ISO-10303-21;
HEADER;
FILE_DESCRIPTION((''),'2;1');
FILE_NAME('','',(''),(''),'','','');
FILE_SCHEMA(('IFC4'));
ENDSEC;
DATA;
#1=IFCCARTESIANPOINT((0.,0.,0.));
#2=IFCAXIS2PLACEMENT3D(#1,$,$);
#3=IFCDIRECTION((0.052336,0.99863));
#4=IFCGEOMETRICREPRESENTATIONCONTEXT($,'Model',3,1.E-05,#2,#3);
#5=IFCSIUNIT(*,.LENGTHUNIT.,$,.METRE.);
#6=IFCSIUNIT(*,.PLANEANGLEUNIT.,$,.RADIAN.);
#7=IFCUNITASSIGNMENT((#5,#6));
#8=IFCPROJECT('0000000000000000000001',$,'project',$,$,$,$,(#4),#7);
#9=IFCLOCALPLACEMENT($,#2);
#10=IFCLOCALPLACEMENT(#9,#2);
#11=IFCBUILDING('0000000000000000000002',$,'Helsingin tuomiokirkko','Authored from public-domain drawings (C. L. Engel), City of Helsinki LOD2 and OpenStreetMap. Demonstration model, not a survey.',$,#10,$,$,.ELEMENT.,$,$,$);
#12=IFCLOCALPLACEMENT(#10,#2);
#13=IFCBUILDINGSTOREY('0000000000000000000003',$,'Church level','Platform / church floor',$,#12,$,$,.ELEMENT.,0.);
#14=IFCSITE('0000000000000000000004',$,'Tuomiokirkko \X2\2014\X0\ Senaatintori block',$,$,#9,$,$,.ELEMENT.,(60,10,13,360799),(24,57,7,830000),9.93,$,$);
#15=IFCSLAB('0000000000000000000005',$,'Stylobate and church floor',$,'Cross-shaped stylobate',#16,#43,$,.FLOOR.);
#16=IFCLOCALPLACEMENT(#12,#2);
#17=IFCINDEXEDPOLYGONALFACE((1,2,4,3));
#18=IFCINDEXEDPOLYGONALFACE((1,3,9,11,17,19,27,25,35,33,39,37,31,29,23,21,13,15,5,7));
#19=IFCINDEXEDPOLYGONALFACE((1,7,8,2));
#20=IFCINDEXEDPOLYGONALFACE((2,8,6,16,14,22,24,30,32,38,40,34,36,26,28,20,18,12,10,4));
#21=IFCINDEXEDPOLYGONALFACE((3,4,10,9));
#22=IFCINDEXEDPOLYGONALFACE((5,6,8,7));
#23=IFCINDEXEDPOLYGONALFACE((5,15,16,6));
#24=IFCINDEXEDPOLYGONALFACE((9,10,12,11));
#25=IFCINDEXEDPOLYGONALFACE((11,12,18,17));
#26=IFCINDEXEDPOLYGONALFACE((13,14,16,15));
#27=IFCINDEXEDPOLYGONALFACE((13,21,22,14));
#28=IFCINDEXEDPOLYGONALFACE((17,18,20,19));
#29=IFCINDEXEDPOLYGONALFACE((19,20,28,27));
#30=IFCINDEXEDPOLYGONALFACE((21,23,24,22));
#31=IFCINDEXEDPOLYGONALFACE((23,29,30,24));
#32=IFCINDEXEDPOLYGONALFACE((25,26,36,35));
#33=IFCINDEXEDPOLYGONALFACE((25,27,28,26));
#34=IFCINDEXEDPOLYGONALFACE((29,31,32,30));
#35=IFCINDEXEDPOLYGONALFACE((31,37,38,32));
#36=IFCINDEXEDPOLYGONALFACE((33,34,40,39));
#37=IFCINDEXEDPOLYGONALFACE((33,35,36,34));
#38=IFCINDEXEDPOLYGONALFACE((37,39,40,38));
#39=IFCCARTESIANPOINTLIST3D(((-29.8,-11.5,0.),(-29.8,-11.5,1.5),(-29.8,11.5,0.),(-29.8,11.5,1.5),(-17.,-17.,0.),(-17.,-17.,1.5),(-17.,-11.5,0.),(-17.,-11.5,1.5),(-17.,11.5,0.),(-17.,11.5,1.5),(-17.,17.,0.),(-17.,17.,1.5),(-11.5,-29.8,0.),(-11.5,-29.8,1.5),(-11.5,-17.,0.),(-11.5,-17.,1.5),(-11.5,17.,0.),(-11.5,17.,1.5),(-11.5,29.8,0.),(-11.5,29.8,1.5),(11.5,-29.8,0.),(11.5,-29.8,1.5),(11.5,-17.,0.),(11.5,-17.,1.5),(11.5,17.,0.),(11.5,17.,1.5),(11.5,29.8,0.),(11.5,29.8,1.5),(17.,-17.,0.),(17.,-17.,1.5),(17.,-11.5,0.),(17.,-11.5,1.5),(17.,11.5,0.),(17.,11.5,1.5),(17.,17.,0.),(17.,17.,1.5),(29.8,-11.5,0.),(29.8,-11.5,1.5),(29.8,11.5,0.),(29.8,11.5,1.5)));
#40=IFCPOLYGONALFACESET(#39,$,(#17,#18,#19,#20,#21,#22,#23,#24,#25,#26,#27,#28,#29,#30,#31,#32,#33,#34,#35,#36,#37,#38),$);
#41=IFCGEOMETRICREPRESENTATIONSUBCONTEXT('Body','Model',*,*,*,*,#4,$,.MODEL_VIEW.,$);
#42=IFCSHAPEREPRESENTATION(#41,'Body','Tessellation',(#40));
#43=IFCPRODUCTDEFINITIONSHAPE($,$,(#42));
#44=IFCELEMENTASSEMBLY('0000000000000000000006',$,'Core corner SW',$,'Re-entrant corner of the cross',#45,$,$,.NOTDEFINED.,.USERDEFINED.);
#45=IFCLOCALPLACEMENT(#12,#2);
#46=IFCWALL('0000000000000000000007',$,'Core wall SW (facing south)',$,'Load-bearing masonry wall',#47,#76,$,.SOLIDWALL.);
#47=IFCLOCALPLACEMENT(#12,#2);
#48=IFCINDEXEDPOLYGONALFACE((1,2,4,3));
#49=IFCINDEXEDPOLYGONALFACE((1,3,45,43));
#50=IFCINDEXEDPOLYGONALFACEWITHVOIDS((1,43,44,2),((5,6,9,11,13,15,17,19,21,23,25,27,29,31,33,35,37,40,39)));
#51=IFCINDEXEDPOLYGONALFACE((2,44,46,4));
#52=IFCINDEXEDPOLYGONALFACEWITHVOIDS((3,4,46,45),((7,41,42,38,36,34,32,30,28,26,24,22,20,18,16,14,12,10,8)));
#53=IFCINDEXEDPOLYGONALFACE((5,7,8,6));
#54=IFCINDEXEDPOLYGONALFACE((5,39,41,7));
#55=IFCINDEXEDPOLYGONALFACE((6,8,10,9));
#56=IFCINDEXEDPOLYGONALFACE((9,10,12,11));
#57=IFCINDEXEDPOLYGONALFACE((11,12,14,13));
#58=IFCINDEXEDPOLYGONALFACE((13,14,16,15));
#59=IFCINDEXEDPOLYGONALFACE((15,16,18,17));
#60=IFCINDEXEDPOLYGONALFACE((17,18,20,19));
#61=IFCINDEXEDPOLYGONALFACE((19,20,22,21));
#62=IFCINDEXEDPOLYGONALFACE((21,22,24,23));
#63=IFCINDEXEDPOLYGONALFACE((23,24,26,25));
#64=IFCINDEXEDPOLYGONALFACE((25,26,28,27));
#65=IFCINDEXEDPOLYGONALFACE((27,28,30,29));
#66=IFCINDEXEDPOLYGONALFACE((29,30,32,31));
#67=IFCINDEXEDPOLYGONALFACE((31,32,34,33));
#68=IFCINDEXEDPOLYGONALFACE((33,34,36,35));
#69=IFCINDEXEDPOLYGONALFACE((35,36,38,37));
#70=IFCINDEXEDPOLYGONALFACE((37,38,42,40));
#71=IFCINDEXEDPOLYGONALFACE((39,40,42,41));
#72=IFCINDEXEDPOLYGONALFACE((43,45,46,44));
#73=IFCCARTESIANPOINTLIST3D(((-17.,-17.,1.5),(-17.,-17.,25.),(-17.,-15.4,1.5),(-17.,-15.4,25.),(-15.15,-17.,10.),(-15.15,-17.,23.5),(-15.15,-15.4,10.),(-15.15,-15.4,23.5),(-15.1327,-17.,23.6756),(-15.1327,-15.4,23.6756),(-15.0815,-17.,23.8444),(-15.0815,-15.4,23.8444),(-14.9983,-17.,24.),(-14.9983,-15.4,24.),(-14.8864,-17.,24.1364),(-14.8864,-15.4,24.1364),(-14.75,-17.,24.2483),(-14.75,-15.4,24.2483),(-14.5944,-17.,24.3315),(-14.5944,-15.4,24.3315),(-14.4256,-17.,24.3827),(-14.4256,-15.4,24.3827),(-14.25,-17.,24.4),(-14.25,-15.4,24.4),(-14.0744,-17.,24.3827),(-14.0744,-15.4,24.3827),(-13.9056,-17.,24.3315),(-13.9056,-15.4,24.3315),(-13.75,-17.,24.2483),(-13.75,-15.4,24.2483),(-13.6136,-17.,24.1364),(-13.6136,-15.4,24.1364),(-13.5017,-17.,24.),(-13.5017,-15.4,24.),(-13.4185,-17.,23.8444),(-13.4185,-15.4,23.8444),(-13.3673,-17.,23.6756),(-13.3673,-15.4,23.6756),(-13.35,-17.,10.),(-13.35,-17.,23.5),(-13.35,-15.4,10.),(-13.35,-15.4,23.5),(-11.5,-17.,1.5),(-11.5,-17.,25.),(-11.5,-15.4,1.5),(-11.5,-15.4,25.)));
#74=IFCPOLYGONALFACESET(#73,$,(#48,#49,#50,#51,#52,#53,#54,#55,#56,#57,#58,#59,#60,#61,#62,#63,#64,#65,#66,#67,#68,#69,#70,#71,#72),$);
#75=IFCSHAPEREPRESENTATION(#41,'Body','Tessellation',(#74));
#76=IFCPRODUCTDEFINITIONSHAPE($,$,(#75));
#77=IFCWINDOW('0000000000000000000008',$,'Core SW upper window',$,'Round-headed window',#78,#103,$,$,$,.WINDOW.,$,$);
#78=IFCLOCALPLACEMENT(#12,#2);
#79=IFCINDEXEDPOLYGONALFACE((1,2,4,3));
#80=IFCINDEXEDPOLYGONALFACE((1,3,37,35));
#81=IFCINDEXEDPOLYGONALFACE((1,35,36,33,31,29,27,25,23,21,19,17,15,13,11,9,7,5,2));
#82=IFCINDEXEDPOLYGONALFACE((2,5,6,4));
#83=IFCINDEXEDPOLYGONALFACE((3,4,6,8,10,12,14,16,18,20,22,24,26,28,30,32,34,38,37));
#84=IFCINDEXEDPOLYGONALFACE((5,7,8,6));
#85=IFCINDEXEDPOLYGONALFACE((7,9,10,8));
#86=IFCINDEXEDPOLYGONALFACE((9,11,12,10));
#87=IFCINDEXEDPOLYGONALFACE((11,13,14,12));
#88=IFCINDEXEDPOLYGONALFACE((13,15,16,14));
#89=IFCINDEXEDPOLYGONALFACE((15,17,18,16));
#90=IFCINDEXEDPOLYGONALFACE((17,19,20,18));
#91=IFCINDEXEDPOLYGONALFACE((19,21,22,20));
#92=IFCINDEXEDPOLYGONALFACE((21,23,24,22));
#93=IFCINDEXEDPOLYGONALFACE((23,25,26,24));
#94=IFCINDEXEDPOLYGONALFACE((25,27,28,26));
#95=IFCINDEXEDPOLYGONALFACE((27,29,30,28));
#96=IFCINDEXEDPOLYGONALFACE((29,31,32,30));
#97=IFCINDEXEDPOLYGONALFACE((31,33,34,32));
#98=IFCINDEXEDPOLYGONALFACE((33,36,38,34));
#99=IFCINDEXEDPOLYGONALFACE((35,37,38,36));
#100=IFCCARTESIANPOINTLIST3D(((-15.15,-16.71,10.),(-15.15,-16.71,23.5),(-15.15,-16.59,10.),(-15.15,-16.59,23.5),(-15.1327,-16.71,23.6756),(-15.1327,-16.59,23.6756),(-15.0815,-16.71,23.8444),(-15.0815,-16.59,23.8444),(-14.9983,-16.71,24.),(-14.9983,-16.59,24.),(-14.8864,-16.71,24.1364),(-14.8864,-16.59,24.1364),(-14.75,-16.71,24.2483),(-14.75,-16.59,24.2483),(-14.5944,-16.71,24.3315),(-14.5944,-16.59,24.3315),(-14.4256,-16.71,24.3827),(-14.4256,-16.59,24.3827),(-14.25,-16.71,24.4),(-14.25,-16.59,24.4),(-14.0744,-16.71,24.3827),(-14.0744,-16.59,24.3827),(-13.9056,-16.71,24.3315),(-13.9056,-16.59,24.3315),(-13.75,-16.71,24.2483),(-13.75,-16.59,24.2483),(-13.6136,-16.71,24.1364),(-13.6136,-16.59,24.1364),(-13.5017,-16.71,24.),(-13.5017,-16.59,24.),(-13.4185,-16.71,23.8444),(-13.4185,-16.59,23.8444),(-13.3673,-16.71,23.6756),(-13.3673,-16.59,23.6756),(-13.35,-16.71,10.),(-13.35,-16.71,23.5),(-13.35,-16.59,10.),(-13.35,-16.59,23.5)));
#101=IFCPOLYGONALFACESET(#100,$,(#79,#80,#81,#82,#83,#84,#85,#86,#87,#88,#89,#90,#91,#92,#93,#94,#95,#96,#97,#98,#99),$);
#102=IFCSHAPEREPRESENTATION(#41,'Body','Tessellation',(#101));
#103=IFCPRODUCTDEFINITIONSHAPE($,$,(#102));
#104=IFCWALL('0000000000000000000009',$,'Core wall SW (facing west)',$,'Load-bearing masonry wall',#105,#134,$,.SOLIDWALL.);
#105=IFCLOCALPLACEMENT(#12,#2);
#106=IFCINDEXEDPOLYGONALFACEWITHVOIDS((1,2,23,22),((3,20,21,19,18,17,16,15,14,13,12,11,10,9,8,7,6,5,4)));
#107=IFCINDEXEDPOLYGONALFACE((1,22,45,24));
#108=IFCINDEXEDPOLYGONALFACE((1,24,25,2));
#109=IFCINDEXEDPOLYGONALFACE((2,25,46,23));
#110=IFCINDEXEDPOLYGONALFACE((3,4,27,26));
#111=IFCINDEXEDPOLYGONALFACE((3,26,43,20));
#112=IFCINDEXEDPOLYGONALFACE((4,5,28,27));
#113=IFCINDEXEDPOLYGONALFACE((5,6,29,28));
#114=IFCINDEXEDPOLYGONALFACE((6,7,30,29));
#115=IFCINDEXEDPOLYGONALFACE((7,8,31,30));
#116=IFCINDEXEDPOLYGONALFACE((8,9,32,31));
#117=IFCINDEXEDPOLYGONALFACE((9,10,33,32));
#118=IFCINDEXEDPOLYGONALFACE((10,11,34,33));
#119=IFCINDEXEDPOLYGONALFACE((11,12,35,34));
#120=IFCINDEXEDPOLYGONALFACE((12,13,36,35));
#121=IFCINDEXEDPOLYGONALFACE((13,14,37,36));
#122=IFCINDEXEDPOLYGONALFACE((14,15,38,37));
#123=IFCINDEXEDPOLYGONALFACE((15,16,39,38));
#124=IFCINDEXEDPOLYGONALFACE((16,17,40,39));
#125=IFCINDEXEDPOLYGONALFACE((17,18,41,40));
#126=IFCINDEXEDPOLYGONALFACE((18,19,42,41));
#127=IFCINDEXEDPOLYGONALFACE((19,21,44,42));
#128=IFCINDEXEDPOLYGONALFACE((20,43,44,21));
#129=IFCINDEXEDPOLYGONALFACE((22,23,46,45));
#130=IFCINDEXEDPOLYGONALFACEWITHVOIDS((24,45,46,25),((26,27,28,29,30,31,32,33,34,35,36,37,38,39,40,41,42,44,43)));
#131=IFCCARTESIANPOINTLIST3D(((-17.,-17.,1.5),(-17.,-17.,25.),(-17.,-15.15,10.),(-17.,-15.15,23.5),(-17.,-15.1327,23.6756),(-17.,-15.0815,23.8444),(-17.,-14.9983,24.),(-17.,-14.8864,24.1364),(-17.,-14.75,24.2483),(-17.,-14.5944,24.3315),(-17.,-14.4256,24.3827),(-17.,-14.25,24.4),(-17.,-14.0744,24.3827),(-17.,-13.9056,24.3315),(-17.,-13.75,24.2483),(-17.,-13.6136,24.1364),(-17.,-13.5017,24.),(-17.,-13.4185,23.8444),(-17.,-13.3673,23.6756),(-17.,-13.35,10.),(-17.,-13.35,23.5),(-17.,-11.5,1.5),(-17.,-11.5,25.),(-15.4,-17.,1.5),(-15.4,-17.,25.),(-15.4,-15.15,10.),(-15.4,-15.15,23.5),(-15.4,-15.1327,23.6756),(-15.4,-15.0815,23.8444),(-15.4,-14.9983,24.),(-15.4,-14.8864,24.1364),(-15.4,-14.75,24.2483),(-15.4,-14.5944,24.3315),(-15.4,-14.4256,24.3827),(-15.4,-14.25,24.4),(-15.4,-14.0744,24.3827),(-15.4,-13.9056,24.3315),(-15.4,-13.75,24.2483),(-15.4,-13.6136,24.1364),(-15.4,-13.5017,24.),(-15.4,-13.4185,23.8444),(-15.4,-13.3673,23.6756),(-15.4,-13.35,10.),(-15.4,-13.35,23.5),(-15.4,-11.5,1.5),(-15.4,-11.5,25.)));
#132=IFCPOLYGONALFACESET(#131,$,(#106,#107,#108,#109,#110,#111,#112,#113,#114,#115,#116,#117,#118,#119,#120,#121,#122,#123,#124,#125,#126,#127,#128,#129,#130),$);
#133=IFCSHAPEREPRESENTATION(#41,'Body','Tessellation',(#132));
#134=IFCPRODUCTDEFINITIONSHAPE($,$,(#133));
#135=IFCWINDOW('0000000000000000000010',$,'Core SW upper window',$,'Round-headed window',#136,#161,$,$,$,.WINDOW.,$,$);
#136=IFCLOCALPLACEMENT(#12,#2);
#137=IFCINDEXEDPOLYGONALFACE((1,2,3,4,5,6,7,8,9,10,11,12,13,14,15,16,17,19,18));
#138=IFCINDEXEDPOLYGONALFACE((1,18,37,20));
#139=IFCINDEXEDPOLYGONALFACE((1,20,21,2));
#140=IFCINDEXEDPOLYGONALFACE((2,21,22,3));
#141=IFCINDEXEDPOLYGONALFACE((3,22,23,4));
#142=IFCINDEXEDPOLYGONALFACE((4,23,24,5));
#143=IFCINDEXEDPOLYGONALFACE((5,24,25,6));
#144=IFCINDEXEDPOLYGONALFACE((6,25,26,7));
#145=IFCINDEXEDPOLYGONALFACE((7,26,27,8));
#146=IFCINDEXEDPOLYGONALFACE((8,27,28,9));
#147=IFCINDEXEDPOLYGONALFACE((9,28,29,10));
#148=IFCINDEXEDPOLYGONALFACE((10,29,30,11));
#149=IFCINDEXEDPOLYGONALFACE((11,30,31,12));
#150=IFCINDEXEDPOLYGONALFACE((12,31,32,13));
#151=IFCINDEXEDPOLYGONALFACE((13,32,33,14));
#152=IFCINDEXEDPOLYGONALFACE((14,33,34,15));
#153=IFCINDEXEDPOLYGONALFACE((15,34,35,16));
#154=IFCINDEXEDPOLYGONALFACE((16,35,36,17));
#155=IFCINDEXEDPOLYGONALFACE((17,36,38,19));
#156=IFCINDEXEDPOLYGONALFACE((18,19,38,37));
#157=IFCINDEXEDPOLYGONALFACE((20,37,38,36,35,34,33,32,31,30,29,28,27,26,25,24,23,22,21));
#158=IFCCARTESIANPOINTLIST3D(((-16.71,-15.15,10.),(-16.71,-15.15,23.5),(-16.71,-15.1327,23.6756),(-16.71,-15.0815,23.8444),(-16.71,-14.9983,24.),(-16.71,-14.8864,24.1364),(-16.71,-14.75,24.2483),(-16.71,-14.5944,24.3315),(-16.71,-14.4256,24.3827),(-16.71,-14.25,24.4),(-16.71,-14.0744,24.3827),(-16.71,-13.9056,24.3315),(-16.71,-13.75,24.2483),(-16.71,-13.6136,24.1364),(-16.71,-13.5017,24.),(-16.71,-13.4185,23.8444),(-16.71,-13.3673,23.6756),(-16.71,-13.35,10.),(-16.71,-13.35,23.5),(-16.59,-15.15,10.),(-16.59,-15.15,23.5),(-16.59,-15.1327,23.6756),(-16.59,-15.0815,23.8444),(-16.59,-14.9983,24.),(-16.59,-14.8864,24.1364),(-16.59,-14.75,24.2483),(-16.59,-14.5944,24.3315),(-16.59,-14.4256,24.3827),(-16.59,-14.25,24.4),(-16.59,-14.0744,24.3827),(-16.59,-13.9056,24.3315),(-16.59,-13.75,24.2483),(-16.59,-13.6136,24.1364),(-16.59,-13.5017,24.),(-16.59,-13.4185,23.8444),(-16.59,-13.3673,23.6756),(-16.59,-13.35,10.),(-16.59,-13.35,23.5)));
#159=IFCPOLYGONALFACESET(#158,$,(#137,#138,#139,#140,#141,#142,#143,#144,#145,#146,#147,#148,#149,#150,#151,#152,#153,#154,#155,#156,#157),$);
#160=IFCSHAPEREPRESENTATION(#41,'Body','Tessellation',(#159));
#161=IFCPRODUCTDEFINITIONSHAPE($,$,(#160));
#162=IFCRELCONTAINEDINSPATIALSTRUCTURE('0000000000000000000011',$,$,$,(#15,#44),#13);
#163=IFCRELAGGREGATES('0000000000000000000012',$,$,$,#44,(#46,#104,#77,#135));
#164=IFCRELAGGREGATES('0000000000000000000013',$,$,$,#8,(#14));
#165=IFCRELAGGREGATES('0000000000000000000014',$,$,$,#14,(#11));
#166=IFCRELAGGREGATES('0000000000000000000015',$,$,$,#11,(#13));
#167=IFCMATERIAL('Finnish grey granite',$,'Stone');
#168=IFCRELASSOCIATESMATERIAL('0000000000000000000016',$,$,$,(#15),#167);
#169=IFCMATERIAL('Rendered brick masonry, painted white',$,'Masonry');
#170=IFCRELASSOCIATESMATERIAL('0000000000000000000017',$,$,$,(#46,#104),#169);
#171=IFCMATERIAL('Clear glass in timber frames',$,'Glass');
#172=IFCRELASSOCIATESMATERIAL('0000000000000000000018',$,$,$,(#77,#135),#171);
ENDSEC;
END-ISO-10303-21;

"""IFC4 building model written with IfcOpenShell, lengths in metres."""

from ifc_helpers import new_model, si_unit, direction, frame, frame_2d, origin, place, context, subcontext, project, spatial, polyline, rectangle, outline, extrude, material, element, fill, aggregate, save


model = new_model("IFC4")

# Units and contexts
model_context = context("Model", 3, precision=1e-05, world=origin(), true_north=direction((0.052336, 0.99863)))
body_context = subcontext(model_context, "Body", "Model", "MODEL_VIEW")
ifc_project = project(units=[si_unit("LENGTHUNIT", "METRE"), si_unit("PLANEANGLEUNIT", "RADIAN")], contexts=[model_context])

# Site, building, storey
site_placement = place(None, origin())
site = spatial("IfcSite", under=ifc_project, at=site_placement, Name="Tuomiokirkko — Senaatintori block", CompositionType="ELEMENT", RefLatitude=(60, 10, 13, 360799), RefLongitude=(24, 57, 7, 830000), RefElevation=9.93)
building_placement = place(site_placement, origin())
building = spatial("IfcBuilding", under=site, at=building_placement, Name="Helsingin tuomiokirkko", Description="Authored from public-domain drawings (C. L. Engel), City of Helsinki LOD2 and OpenStreetMap. Demonstration model, not a survey.", CompositionType="ELEMENT")
storey_placement = place(building_placement, origin())
storey = spatial("IfcBuildingStorey", under=building, at=storey_placement, Name="Church level", Description="Platform / church floor", CompositionType="ELEMENT", Elevation=0.0)

# Slab
ifc_material_1 = material(Name="Finnish grey granite", Category="Stone")
slab_placement = place(building_placement, origin())
element("IfcSlab", 1, at=slab_placement, inside=storey, material=ifc_material_1, Name="Stylobate and church floor", ObjectType="Cross-shaped stylobate", PredefinedType="FLOOR", context=body_context, shape_type="SweptSolid", body=[
    extrude(outline(polyline([(-11.5, -29.8), (11.5, -29.8), (11.5, -17.0), (17.0, -17.0), (17.0, -11.5), (29.8, -11.5), (29.8, 11.5), (17.0, 11.5), (17.0, 17.0), (11.5, 17.0), (11.5, 29.8), (-11.5, 29.8), (-11.5, 17.0), (-17.0, 17.0), (-17.0, 11.5), (-29.8, 11.5), (-29.8, -11.5), (-17.0, -11.5), (-17.0, -17.0), (-11.5, -17.0), (-11.5, -29.8)])), origin(), (0.0, 0.0, 1.0), 1.5),
])

# Element assembly, walls, openings, windows
assembly_1_placement = place(building_placement, origin())
assembly_1 = element("IfcElementAssembly", 2, at=assembly_1_placement, inside=storey, Name="Core corner SW", ObjectType="Re-entrant corner of the cross", AssemblyPlace="NOTDEFINED", PredefinedType="USERDEFINED")
ifc_material_2 = material(Name="Rendered brick masonry, painted white", Category="Masonry")
wall_1_placement = place(building_placement, origin())
wall_1 = element("IfcWall", 3, at=wall_1_placement, material=ifc_material_2, Name="Core wall SW (facing south)", ObjectType="Load-bearing masonry wall", PredefinedType="SOLIDWALL", context=body_context, shape_type="SweptSolid", body=[
    extrude(rectangle(XDim=5.5, YDim=1.6, at=frame_2d((0.0, 0.0), x_axis=(-1.0, 0.0))), frame((-14.25, -16.2, 1.5)), (0.0, 0.0, 1.0), 23.5),
])
opening_1_placement = place(building_placement, origin())
opening_1 = element("IfcOpeningElement", 4, at=opening_1_placement, cuts=wall_1, PredefinedType="OPENING", context=body_context, shape_type="SweptSolid", body=[
    extrude(outline(polyline([(-0.9, 0.0), (0.9, 0.0), (0.9, 13.5), (0.8827, 13.6756), (0.8315, 13.8444), (0.7483, 14.0), (0.6364, 14.1364), (0.5, 14.2483), (0.3444, 14.3315), (0.1756, 14.3827), (0.0, 14.4), (-0.1756, 14.3827), (-0.3444, 14.3315), (-0.5, 14.2483), (-0.6364, 14.1364), (-0.7483, 14.0), (-0.8315, 13.8444), (-0.8827, 13.6756), (-0.9, 13.5), (-0.9, 0.0)])), frame((-14.25, -17.2, 10.0), z_axis=(0.0, 1.0, 0.0), x_axis=(-1.0, 0.0, 0.0)), (0.0, 0.0, 1.0), 2.0),
])
ifc_material_3 = material(Name="Clear glass in timber frames", Category="Glass")
window_1_placement = place(building_placement, origin())
window_1 = element("IfcWindow", 5, at=window_1_placement, material=ifc_material_3, Name="Core SW upper window", ObjectType="Round-headed window", PredefinedType="WINDOW", context=body_context, shape_type="SweptSolid", body=[
    extrude(outline(polyline([(-0.9, 0.0), (0.9, 0.0), (0.9, 13.5), (0.8827, 13.6756), (0.8315, 13.8444), (0.7483, 14.0), (0.6364, 14.1364), (0.5, 14.2483), (0.3444, 14.3315), (0.1756, 14.3827), (0.0, 14.4), (-0.1756, 14.3827), (-0.3444, 14.3315), (-0.5, 14.2483), (-0.6364, 14.1364), (-0.7483, 14.0), (-0.8315, 13.8444), (-0.8827, 13.6756), (-0.9, 13.5), (-0.9, 0.0)])), frame((-14.25, -16.71, 10.0), z_axis=(0.0, 1.0, 0.0), x_axis=(-1.0, 0.0, 0.0)), (0.0, 0.0, 1.0), 0.12),
])
fill(opening_1, window_1)
wall_2_placement = place(building_placement, origin())
wall_2 = element("IfcWall", 6, at=wall_2_placement, material=ifc_material_2, Name="Core wall SW (facing west)", ObjectType="Load-bearing masonry wall", PredefinedType="SOLIDWALL", context=body_context, shape_type="SweptSolid", body=[
    extrude(rectangle(XDim=5.5, YDim=1.6, at=frame_2d((0.0, 0.0), x_axis=(0.0, -1.0))), frame((-16.2, -14.25, 1.5)), (0.0, 0.0, 1.0), 23.5),
])
opening_2_placement = place(building_placement, origin())
opening_2 = element("IfcOpeningElement", 7, at=opening_2_placement, cuts=wall_2, PredefinedType="OPENING", context=body_context, shape_type="SweptSolid", body=[
    extrude(outline(polyline([(-0.9, 0.0), (0.9, 0.0), (0.9, 13.5), (0.8827, 13.6756), (0.8315, 13.8444), (0.7483, 14.0), (0.6364, 14.1364), (0.5, 14.2483), (0.3444, 14.3315), (0.1756, 14.3827), (0.0, 14.4), (-0.1756, 14.3827), (-0.3444, 14.3315), (-0.5, 14.2483), (-0.6364, 14.1364), (-0.7483, 14.0), (-0.8315, 13.8444), (-0.8827, 13.6756), (-0.9, 13.5), (-0.9, 0.0)])), frame((-15.2, -14.25, 10.0), z_axis=(-1.0, 0.0, 0.0), x_axis=(0.0, -1.0, 0.0)), (0.0, 0.0, 1.0), 2.0),
])
window_2_placement = place(building_placement, origin())
window_2 = element("IfcWindow", 8, at=window_2_placement, material=ifc_material_3, Name="Core SW upper window", ObjectType="Round-headed window", PredefinedType="WINDOW", context=body_context, shape_type="SweptSolid", body=[
    extrude(outline(polyline([(-0.9, 0.0), (0.9, 0.0), (0.9, 13.5), (0.8827, 13.6756), (0.8315, 13.8444), (0.7483, 14.0), (0.6364, 14.1364), (0.5, 14.2483), (0.3444, 14.3315), (0.1756, 14.3827), (0.0, 14.4), (-0.1756, 14.3827), (-0.3444, 14.3315), (-0.5, 14.2483), (-0.6364, 14.1364), (-0.7483, 14.0), (-0.8315, 13.8444), (-0.8827, 13.6756), (-0.9, 13.5), (-0.9, 0.0)])), frame((-16.59, -14.25, 10.0), z_axis=(-1.0, 0.0, 0.0), x_axis=(0.0, -1.0, 0.0)), (0.0, 0.0, 1.0), 0.12),
])
fill(opening_2, window_2)
aggregate(assembly_1, [wall_1, wall_2, window_1, window_2])

save(model, "model.ifc")
